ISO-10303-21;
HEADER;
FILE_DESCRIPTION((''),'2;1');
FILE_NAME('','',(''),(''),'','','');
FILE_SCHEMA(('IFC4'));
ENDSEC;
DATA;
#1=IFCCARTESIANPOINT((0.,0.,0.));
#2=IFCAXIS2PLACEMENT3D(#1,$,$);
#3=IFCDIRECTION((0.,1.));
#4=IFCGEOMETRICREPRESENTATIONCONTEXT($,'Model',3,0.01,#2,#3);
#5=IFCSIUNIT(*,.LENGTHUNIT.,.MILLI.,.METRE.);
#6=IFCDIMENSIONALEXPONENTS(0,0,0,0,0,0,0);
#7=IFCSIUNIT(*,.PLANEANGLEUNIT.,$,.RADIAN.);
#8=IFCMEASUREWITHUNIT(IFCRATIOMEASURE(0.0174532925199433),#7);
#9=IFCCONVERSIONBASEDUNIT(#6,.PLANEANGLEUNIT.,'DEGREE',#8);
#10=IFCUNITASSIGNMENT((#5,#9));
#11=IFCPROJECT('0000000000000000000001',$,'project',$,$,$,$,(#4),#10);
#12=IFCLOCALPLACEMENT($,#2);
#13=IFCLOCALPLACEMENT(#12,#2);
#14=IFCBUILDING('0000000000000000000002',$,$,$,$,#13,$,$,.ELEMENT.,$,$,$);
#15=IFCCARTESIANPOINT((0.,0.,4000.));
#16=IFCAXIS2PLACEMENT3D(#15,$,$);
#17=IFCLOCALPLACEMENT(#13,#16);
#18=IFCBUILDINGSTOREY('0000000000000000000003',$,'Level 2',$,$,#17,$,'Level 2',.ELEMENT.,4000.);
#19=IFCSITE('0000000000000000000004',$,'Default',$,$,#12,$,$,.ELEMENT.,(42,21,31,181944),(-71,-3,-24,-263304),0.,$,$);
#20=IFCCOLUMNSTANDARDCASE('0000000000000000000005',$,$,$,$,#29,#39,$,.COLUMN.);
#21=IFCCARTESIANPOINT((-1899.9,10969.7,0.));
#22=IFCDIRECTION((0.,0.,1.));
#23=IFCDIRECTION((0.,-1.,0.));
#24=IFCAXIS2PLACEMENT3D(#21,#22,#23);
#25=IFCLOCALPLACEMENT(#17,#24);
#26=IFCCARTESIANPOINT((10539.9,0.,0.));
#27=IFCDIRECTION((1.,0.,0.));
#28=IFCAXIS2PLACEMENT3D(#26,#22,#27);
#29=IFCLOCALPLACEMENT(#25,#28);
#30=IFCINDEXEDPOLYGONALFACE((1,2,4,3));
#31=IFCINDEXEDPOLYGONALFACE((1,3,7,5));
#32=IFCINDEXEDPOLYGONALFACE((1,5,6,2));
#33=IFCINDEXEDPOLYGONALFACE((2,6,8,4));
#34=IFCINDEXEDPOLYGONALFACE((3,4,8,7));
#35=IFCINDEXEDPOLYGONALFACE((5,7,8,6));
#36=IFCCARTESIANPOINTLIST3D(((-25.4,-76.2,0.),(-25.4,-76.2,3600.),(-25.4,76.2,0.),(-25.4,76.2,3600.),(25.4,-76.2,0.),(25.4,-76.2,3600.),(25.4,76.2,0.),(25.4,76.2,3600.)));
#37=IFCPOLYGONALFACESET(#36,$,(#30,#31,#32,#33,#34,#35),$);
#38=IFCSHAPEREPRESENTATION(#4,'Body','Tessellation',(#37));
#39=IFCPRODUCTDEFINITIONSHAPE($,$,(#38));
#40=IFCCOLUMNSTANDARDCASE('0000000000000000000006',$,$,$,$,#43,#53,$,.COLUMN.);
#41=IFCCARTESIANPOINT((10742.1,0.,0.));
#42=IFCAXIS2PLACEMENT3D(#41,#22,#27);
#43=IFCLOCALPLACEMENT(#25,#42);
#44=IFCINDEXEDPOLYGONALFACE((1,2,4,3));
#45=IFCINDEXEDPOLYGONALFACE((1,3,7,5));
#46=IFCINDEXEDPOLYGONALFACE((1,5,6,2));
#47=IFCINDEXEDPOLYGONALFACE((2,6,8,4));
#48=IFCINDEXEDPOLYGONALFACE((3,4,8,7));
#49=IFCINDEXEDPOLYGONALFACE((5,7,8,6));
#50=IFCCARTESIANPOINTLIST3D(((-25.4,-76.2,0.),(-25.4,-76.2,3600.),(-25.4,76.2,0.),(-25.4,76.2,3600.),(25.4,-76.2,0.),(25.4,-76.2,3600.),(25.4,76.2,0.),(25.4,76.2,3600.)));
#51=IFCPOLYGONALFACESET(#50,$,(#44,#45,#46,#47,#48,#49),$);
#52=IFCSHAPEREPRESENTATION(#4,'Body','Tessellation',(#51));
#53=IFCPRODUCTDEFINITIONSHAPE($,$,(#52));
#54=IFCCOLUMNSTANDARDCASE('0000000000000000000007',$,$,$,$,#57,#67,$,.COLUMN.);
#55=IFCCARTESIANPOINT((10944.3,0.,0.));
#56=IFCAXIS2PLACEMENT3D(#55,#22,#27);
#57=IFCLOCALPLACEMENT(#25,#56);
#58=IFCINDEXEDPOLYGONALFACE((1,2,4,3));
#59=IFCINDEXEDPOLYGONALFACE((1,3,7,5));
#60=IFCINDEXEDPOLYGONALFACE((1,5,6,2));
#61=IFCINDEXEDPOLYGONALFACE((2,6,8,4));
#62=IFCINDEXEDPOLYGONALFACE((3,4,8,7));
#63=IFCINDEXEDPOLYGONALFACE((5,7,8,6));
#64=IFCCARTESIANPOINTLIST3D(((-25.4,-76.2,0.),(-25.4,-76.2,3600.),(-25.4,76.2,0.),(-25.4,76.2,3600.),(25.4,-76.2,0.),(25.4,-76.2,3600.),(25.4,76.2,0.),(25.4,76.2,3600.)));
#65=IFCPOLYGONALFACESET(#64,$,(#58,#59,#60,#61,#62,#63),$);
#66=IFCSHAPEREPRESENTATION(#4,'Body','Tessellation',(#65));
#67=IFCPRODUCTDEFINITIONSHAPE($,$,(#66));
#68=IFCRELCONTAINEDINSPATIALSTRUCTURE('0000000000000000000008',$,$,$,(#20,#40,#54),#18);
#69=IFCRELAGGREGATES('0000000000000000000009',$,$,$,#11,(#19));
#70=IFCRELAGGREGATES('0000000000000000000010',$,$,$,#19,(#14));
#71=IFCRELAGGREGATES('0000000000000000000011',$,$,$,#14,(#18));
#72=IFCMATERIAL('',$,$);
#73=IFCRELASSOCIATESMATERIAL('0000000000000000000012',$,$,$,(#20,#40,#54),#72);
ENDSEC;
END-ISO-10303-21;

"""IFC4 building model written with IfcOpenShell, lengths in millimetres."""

from ifc_helpers import new_model, entity, si_unit, converted_unit, direction, frame, origin, place, context, project, spatial, rectangle, extrude, material, element, save


model = new_model("IFC4")

# Units and contexts
model_context = context("Model", 3, precision=0.01, world=origin(), true_north=direction((0.0, 1.0)))
ifc_project = project(units=[si_unit("LENGTHUNIT", "METRE", prefix="MILLI"), converted_unit("PLANEANGLEUNIT", "DEGREE", entity("IfcRatioMeasure", 0.0174532925199433), si_unit("PLANEANGLEUNIT", "RADIAN"), dimensions=[0, 0, 0, 0, 0, 0, 0])], contexts=[model_context])

# Site, building, storey
site_placement = place(None, origin())
site = spatial("IfcSite", under=ifc_project, at=site_placement, Name="Default", CompositionType="ELEMENT", RefLatitude=(42, 21, 31, 181944), RefLongitude=(-71, -3, -24, -263304), RefElevation=0.0)
building_placement = place(site_placement, origin())
building = spatial("IfcBuilding", under=site, at=building_placement, CompositionType="ELEMENT")
storey_placement = place(building_placement, frame((0.0, 0.0, 4000.0)))
storey = spatial("IfcBuildingStorey", under=building, at=storey_placement, Name="Level 2", LongName="Level 2", CompositionType="ELEMENT", Elevation=4000.0)

# Columns
ifc_material_1 = material(Name="")
placement_1 = place(storey_placement, frame((-1899.9, 10969.7, 0.0), z_axis=(0.0, 0.0, 1.0), x_axis=(0.0, -1.0, 0.0)))
for number, where, z_axis, x_axis in (
    (1, (10539.9, 0.0, 0.0), (0.0, 0.0, 1.0), (1.0, 0.0, 0.0)),
    (2, (10742.1, 0.0, 0.0), (0.0, 0.0, 1.0), (1.0, 0.0, 0.0)),
    (3, (10944.3, 0.0, 0.0), (0.0, 0.0, 1.0), (1.0, 0.0, 0.0)),
):
    element("IfcColumnStandardCase", number, at=place(placement_1, frame(where, z_axis=z_axis, x_axis=x_axis)), inside=storey, material=ifc_material_1, PredefinedType="COLUMN", context=model_context, shape_type="SweptSolid", body=[
        extrude(rectangle(XDim=50.8, YDim=152.4), origin(), (0.0, 0.0, 1.0), 3600.0),
    ])

save(model, "model.ifc")
